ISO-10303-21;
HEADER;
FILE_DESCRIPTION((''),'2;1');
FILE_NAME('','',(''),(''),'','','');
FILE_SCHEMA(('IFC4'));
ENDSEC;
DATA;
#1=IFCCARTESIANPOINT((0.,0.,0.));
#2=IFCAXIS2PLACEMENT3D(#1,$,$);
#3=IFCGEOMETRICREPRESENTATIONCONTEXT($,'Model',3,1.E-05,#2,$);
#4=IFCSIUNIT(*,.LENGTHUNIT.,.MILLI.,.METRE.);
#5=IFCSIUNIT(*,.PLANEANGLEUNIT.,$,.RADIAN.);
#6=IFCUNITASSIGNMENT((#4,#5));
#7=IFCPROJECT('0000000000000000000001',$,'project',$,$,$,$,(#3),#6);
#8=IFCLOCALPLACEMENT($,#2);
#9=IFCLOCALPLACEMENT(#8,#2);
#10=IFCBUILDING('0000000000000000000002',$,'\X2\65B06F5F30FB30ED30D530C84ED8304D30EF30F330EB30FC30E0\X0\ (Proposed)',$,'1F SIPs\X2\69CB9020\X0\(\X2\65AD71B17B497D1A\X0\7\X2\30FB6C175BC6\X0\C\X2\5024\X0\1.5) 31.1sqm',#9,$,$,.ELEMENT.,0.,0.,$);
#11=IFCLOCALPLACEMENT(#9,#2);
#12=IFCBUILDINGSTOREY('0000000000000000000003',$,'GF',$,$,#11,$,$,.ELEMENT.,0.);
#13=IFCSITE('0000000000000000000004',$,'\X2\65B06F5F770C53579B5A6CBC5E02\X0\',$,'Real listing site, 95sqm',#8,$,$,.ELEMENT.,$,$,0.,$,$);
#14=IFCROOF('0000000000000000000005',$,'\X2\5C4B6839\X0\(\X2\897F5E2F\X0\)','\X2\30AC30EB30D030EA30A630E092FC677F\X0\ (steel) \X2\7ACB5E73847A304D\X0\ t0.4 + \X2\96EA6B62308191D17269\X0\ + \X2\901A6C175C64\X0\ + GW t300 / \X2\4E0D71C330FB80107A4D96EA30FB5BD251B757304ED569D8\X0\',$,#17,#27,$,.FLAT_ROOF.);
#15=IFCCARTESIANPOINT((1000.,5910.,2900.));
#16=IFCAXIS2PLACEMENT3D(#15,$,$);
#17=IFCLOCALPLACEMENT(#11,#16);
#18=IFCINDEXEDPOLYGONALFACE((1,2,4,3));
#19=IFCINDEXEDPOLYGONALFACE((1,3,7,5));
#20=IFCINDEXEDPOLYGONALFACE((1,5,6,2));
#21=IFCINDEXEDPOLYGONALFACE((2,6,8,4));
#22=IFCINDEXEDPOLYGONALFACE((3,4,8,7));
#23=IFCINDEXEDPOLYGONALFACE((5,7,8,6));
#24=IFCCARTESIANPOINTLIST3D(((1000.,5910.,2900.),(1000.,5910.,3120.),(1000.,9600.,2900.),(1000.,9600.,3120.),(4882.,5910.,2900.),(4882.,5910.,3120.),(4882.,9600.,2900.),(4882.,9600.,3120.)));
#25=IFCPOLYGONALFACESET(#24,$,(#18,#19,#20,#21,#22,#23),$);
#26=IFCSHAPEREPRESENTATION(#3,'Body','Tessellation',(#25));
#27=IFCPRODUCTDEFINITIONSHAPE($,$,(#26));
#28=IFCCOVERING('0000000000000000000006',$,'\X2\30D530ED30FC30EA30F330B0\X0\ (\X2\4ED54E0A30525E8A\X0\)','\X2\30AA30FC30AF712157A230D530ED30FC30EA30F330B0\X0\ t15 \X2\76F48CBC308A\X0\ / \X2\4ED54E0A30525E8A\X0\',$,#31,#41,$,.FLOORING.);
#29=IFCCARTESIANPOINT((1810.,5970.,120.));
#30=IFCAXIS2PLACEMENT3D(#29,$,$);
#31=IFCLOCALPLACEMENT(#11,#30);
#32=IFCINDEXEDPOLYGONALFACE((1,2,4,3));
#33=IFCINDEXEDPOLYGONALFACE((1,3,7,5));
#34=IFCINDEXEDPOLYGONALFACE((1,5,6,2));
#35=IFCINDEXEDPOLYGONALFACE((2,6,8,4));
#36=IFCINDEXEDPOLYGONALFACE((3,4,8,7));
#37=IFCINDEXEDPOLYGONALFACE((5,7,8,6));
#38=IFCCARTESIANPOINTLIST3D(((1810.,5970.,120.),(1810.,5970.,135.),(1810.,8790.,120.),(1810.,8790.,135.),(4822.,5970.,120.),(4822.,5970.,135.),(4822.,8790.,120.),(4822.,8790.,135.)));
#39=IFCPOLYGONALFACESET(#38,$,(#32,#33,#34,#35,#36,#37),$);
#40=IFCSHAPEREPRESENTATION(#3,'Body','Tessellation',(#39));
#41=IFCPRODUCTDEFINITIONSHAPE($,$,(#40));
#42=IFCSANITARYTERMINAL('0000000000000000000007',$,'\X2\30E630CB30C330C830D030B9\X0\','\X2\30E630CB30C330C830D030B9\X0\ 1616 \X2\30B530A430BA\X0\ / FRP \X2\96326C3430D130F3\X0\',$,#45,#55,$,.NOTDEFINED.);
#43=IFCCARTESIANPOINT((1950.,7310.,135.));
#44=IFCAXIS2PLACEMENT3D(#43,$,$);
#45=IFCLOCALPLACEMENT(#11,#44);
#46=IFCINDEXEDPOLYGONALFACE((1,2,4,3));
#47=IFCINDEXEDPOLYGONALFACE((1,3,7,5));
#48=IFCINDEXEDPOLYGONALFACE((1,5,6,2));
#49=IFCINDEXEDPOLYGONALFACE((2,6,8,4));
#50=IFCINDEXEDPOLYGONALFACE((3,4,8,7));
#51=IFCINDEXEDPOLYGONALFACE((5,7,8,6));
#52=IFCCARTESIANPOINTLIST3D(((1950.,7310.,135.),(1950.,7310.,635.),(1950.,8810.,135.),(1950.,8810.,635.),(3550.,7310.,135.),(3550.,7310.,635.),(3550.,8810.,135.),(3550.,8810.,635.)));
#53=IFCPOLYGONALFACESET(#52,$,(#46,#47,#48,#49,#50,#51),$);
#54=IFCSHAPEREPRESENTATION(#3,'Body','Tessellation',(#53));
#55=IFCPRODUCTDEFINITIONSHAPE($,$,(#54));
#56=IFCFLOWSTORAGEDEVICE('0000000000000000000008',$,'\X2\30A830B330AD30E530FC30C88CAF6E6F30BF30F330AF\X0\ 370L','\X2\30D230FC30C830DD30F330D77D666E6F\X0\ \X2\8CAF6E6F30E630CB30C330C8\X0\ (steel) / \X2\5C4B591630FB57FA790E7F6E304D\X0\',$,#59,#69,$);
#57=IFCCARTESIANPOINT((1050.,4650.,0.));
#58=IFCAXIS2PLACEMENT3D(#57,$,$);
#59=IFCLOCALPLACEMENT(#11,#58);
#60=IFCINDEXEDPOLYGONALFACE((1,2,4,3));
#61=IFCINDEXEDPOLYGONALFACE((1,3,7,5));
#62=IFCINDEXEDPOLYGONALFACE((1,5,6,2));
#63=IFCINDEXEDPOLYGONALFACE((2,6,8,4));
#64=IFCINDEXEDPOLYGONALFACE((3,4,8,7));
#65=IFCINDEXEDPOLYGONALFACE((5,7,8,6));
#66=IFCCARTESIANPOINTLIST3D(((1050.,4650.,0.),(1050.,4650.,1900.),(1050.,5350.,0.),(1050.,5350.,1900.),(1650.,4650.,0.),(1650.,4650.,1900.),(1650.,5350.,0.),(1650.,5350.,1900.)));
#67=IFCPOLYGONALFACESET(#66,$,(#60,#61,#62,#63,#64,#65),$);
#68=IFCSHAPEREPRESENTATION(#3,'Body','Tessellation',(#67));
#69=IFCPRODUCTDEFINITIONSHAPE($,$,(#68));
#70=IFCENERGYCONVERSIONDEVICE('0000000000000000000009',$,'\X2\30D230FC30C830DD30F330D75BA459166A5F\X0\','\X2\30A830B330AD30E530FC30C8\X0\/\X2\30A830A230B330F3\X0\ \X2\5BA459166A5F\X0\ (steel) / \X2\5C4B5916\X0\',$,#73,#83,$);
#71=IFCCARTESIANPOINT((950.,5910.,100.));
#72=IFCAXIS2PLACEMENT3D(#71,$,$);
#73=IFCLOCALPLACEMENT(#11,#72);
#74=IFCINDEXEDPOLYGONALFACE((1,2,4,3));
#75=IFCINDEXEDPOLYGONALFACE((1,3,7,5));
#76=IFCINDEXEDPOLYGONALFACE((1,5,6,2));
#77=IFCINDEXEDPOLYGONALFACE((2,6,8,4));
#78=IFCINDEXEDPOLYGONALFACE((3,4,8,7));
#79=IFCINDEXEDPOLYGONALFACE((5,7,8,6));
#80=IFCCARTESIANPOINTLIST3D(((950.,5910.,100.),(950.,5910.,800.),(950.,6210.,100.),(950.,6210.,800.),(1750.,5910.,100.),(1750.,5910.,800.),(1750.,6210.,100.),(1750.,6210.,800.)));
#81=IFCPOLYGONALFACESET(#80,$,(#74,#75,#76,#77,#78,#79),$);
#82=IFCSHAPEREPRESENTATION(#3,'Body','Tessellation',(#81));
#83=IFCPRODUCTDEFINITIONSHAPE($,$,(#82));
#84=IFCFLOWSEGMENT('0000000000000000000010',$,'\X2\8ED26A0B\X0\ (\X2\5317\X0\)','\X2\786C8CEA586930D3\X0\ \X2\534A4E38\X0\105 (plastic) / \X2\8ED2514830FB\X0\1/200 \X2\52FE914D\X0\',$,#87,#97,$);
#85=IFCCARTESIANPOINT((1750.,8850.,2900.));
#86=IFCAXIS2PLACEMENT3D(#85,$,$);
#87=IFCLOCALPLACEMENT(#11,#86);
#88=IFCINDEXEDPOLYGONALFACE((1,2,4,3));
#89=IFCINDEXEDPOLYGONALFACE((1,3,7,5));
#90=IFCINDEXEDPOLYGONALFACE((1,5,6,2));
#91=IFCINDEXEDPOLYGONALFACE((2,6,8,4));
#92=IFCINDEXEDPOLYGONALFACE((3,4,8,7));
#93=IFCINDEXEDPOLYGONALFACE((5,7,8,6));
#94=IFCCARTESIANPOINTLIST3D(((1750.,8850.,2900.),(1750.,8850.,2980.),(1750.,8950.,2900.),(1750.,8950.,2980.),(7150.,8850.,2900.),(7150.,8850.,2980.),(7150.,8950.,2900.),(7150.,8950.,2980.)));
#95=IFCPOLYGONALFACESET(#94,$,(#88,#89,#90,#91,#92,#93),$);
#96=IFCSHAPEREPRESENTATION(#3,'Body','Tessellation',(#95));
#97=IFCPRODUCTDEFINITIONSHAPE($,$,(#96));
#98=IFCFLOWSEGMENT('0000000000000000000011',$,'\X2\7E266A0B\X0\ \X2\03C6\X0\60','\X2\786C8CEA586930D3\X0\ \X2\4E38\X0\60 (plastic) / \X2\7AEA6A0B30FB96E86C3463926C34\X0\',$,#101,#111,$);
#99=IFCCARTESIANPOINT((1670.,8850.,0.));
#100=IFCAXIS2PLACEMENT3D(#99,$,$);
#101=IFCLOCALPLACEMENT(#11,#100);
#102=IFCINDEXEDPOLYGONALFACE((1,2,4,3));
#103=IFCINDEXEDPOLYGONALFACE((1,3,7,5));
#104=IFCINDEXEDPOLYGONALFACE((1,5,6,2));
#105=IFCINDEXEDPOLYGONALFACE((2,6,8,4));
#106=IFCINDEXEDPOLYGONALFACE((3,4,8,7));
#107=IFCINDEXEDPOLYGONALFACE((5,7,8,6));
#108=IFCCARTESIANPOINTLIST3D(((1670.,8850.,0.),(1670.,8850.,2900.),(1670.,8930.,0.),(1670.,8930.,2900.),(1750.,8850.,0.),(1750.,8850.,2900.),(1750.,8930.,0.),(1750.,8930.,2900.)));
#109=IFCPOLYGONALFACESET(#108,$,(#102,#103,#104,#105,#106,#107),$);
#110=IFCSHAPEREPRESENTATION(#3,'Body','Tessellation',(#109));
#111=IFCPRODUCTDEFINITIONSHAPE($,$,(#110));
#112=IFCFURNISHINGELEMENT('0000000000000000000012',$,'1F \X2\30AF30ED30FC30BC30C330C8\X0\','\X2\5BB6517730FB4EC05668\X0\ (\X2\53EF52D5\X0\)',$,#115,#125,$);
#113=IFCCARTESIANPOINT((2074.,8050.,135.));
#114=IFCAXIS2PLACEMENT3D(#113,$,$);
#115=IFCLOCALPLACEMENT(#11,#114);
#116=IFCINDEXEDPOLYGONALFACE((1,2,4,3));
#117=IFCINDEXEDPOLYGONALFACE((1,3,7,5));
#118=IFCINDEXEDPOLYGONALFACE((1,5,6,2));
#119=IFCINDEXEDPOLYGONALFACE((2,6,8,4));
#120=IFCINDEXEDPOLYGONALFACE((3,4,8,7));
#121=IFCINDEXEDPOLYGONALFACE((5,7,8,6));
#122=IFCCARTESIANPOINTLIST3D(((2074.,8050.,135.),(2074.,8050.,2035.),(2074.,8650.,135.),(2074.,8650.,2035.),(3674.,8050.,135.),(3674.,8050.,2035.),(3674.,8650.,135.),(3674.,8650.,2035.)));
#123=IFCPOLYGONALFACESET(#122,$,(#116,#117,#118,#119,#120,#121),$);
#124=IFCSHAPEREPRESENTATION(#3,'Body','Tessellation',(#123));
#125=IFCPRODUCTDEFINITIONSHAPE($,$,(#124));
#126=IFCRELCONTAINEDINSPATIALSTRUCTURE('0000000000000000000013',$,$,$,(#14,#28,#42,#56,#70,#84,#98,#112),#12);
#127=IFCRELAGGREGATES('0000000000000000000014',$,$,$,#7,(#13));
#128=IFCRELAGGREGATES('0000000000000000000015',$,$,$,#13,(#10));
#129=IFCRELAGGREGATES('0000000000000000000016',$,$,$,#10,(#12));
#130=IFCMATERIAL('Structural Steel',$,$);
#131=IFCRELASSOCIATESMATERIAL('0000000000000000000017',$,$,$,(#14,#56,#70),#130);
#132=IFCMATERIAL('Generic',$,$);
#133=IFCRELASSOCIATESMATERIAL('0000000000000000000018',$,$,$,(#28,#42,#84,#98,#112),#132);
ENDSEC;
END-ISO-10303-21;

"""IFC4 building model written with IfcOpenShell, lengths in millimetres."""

from ifc_helpers import new_model, si_unit, frame, frame_2d, origin, place, context, project, spatial, rectangle, extrude, material, element, save


model = new_model("IFC4")

# Units and contexts
model_context = context("Model", 3, precision=1e-05, world=origin())
ifc_project = project(units=[si_unit("LENGTHUNIT", "METRE", prefix="MILLI"), si_unit("PLANEANGLEUNIT", "RADIAN")], contexts=[model_context])

# Site, building, storey
site_placement = place(None, origin())
site = spatial("IfcSite", under=ifc_project, at=site_placement, Name="新潟県南魚沼市", ObjectType="Real listing site, 95sqm", CompositionType="ELEMENT", RefElevation=0.0)
building_placement = place(site_placement, origin())
building = spatial("IfcBuilding", under=site, at=building_placement, Name="新潟・ロフト付きワンルーム (Proposed)", ObjectType="1F SIPs構造(断熱等級7・気密C値1.5) 31.1sqm", CompositionType="ELEMENT", ElevationOfRefHeight=0.0, ElevationOfTerrain=0.0)
storey_placement = place(building_placement, origin())
storey = spatial("IfcBuildingStorey", under=building, at=storey_placement, Name="GF", CompositionType="ELEMENT", Elevation=0.0)

# Roof
ifc_material_1 = material(Name="Structural Steel")
roof_placement = place(storey_placement, frame((1000.0, 5910.0, 2900.0)))
element("IfcRoof", 1, at=roof_placement, inside=storey, material=ifc_material_1, Name="屋根(西帯)", Description="ガルバリウム鋼板 (steel) 立平葺き t0.4 + 雪止め金物 + 通気層 + GW t300 / 不燃・耐積雪・寒冷地仕様", PredefinedType="FLAT_ROOF", context=model_context, shape_type="SweptSolid", body=[
    extrude(rectangle(XDim=3882.0, YDim=3690.0, at=frame_2d((1941.0, 1845.0))), frame((1000.0, 5910.0, 2900.0)), (0.0, 0.0, 1.0), 220.0),
])

# Covering
ifc_material_2 = material(Name="Generic")
covering_placement = place(storey_placement, frame((1810.0, 5970.0, 120.0)))
element("IfcCovering", 2, at=covering_placement, inside=storey, material=ifc_material_2, Name="フローリング (仕上げ床)", Description="オーク無垢フローリング t15 直貼り / 仕上げ床", PredefinedType="FLOORING", context=model_context, shape_type="SweptSolid", body=[
    extrude(rectangle(XDim=3012.0, YDim=2820.0, at=frame_2d((1506.0, 1410.0))), frame((1810.0, 5970.0, 120.0)), (0.0, 0.0, 1.0), 15.0),
])

# Sanitary terminal
sanitary_terminal_placement = place(storey_placement, frame((1950.0, 7310.0, 135.0)))
element("IfcSanitaryTerminal", 3, at=sanitary_terminal_placement, inside=storey, material=ifc_material_2, Name="ユニットバス", Description="ユニットバス 1616 サイズ / FRP 防水パン", PredefinedType="NOTDEFINED", context=model_context, shape_type="SweptSolid", body=[
    extrude(rectangle(XDim=1600.0, YDim=1500.0, at=frame_2d((800.0, 750.0))), frame((1950.0, 7310.0, 135.0)), (0.0, 0.0, 1.0), 500.0),
])

# Flow storage device
flow_storage_device_placement = place(storey_placement, frame((1050.0, 4650.0, 0.0)))
element("IfcFlowStorageDevice", 4, at=flow_storage_device_placement, inside=storey, material=ifc_material_1, Name="エコキュート貯湯タンク 370L", Description="ヒートポンプ給湯 貯湯ユニット (steel) / 屋外・基礎置き", context=model_context, shape_type="SweptSolid", body=[
    extrude(rectangle(XDim=600.0, YDim=700.0, at=frame_2d((300.0, 350.0))), frame((1050.0, 4650.0, 0.0)), (0.0, 0.0, 1.0), 1900.0),
])

# Energy conversion device
energy_conversion_device_placement = place(storey_placement, frame((950.0, 5910.0, 100.0)))
element("IfcEnergyConversionDevice", 5, at=energy_conversion_device_placement, inside=storey, material=ifc_material_1, Name="ヒートポンプ室外機", Description="エコキュート/エアコン 室外機 (steel) / 屋外", context=model_context, shape_type="SweptSolid", body=[
    extrude(rectangle(XDim=800.0, YDim=300.0, at=frame_2d((400.0, 150.0))), frame((950.0, 5910.0, 100.0)), (0.0, 0.0, 1.0), 700.0),
])

# Flow segments
flow_segment_1_placement = place(storey_placement, frame((1750.0, 8850.0, 2900.0)))
element("IfcFlowSegment", 6, at=flow_segment_1_placement, inside=storey, material=ifc_material_2, Name="軒樋 (北)", Description="硬質塩ビ 半丸105 (plastic) / 軒先・1/200 勾配", context=model_context, shape_type="SweptSolid", body=[
    extrude(rectangle(XDim=5400.0, YDim=100.0, at=frame_2d((2700.0, 50.0))), frame((1750.0, 8850.0, 2900.0)), (0.0, 0.0, 1.0), 80.0),
])
flow_segment_2_placement = place(storey_placement, frame((1670.0, 8850.0, 0.0)))
element("IfcFlowSegment", 7, at=flow_segment_2_placement, inside=storey, material=ifc_material_2, Name="縦樋 φ60", Description="硬質塩ビ 丸60 (plastic) / 竪樋・雨水排水", context=model_context, shape_type="SweptSolid", body=[
    extrude(rectangle(XDim=80.0, YDim=80.0, at=frame_2d((40.0, 40.0))), frame((1670.0, 8850.0, 0.0)), (0.0, 0.0, 1.0), 2900.0),
])

# Furnishing element
furnishing_placement = place(storey_placement, frame((2074.0, 8050.0, 135.0)))
element("IfcFurnishingElement", 8, at=furnishing_placement, inside=storey, material=ifc_material_2, Name="1F クローゼット", Description="家具・什器 (可動)", context=model_context, shape_type="SweptSolid", body=[
    extrude(rectangle(XDim=1600.0, YDim=600.0, at=frame_2d((800.0, 300.0))), frame((2074.0, 8050.0, 135.0)), (0.0, 0.0, 1.0), 1900.0),
])

save(model, "model.ifc")
